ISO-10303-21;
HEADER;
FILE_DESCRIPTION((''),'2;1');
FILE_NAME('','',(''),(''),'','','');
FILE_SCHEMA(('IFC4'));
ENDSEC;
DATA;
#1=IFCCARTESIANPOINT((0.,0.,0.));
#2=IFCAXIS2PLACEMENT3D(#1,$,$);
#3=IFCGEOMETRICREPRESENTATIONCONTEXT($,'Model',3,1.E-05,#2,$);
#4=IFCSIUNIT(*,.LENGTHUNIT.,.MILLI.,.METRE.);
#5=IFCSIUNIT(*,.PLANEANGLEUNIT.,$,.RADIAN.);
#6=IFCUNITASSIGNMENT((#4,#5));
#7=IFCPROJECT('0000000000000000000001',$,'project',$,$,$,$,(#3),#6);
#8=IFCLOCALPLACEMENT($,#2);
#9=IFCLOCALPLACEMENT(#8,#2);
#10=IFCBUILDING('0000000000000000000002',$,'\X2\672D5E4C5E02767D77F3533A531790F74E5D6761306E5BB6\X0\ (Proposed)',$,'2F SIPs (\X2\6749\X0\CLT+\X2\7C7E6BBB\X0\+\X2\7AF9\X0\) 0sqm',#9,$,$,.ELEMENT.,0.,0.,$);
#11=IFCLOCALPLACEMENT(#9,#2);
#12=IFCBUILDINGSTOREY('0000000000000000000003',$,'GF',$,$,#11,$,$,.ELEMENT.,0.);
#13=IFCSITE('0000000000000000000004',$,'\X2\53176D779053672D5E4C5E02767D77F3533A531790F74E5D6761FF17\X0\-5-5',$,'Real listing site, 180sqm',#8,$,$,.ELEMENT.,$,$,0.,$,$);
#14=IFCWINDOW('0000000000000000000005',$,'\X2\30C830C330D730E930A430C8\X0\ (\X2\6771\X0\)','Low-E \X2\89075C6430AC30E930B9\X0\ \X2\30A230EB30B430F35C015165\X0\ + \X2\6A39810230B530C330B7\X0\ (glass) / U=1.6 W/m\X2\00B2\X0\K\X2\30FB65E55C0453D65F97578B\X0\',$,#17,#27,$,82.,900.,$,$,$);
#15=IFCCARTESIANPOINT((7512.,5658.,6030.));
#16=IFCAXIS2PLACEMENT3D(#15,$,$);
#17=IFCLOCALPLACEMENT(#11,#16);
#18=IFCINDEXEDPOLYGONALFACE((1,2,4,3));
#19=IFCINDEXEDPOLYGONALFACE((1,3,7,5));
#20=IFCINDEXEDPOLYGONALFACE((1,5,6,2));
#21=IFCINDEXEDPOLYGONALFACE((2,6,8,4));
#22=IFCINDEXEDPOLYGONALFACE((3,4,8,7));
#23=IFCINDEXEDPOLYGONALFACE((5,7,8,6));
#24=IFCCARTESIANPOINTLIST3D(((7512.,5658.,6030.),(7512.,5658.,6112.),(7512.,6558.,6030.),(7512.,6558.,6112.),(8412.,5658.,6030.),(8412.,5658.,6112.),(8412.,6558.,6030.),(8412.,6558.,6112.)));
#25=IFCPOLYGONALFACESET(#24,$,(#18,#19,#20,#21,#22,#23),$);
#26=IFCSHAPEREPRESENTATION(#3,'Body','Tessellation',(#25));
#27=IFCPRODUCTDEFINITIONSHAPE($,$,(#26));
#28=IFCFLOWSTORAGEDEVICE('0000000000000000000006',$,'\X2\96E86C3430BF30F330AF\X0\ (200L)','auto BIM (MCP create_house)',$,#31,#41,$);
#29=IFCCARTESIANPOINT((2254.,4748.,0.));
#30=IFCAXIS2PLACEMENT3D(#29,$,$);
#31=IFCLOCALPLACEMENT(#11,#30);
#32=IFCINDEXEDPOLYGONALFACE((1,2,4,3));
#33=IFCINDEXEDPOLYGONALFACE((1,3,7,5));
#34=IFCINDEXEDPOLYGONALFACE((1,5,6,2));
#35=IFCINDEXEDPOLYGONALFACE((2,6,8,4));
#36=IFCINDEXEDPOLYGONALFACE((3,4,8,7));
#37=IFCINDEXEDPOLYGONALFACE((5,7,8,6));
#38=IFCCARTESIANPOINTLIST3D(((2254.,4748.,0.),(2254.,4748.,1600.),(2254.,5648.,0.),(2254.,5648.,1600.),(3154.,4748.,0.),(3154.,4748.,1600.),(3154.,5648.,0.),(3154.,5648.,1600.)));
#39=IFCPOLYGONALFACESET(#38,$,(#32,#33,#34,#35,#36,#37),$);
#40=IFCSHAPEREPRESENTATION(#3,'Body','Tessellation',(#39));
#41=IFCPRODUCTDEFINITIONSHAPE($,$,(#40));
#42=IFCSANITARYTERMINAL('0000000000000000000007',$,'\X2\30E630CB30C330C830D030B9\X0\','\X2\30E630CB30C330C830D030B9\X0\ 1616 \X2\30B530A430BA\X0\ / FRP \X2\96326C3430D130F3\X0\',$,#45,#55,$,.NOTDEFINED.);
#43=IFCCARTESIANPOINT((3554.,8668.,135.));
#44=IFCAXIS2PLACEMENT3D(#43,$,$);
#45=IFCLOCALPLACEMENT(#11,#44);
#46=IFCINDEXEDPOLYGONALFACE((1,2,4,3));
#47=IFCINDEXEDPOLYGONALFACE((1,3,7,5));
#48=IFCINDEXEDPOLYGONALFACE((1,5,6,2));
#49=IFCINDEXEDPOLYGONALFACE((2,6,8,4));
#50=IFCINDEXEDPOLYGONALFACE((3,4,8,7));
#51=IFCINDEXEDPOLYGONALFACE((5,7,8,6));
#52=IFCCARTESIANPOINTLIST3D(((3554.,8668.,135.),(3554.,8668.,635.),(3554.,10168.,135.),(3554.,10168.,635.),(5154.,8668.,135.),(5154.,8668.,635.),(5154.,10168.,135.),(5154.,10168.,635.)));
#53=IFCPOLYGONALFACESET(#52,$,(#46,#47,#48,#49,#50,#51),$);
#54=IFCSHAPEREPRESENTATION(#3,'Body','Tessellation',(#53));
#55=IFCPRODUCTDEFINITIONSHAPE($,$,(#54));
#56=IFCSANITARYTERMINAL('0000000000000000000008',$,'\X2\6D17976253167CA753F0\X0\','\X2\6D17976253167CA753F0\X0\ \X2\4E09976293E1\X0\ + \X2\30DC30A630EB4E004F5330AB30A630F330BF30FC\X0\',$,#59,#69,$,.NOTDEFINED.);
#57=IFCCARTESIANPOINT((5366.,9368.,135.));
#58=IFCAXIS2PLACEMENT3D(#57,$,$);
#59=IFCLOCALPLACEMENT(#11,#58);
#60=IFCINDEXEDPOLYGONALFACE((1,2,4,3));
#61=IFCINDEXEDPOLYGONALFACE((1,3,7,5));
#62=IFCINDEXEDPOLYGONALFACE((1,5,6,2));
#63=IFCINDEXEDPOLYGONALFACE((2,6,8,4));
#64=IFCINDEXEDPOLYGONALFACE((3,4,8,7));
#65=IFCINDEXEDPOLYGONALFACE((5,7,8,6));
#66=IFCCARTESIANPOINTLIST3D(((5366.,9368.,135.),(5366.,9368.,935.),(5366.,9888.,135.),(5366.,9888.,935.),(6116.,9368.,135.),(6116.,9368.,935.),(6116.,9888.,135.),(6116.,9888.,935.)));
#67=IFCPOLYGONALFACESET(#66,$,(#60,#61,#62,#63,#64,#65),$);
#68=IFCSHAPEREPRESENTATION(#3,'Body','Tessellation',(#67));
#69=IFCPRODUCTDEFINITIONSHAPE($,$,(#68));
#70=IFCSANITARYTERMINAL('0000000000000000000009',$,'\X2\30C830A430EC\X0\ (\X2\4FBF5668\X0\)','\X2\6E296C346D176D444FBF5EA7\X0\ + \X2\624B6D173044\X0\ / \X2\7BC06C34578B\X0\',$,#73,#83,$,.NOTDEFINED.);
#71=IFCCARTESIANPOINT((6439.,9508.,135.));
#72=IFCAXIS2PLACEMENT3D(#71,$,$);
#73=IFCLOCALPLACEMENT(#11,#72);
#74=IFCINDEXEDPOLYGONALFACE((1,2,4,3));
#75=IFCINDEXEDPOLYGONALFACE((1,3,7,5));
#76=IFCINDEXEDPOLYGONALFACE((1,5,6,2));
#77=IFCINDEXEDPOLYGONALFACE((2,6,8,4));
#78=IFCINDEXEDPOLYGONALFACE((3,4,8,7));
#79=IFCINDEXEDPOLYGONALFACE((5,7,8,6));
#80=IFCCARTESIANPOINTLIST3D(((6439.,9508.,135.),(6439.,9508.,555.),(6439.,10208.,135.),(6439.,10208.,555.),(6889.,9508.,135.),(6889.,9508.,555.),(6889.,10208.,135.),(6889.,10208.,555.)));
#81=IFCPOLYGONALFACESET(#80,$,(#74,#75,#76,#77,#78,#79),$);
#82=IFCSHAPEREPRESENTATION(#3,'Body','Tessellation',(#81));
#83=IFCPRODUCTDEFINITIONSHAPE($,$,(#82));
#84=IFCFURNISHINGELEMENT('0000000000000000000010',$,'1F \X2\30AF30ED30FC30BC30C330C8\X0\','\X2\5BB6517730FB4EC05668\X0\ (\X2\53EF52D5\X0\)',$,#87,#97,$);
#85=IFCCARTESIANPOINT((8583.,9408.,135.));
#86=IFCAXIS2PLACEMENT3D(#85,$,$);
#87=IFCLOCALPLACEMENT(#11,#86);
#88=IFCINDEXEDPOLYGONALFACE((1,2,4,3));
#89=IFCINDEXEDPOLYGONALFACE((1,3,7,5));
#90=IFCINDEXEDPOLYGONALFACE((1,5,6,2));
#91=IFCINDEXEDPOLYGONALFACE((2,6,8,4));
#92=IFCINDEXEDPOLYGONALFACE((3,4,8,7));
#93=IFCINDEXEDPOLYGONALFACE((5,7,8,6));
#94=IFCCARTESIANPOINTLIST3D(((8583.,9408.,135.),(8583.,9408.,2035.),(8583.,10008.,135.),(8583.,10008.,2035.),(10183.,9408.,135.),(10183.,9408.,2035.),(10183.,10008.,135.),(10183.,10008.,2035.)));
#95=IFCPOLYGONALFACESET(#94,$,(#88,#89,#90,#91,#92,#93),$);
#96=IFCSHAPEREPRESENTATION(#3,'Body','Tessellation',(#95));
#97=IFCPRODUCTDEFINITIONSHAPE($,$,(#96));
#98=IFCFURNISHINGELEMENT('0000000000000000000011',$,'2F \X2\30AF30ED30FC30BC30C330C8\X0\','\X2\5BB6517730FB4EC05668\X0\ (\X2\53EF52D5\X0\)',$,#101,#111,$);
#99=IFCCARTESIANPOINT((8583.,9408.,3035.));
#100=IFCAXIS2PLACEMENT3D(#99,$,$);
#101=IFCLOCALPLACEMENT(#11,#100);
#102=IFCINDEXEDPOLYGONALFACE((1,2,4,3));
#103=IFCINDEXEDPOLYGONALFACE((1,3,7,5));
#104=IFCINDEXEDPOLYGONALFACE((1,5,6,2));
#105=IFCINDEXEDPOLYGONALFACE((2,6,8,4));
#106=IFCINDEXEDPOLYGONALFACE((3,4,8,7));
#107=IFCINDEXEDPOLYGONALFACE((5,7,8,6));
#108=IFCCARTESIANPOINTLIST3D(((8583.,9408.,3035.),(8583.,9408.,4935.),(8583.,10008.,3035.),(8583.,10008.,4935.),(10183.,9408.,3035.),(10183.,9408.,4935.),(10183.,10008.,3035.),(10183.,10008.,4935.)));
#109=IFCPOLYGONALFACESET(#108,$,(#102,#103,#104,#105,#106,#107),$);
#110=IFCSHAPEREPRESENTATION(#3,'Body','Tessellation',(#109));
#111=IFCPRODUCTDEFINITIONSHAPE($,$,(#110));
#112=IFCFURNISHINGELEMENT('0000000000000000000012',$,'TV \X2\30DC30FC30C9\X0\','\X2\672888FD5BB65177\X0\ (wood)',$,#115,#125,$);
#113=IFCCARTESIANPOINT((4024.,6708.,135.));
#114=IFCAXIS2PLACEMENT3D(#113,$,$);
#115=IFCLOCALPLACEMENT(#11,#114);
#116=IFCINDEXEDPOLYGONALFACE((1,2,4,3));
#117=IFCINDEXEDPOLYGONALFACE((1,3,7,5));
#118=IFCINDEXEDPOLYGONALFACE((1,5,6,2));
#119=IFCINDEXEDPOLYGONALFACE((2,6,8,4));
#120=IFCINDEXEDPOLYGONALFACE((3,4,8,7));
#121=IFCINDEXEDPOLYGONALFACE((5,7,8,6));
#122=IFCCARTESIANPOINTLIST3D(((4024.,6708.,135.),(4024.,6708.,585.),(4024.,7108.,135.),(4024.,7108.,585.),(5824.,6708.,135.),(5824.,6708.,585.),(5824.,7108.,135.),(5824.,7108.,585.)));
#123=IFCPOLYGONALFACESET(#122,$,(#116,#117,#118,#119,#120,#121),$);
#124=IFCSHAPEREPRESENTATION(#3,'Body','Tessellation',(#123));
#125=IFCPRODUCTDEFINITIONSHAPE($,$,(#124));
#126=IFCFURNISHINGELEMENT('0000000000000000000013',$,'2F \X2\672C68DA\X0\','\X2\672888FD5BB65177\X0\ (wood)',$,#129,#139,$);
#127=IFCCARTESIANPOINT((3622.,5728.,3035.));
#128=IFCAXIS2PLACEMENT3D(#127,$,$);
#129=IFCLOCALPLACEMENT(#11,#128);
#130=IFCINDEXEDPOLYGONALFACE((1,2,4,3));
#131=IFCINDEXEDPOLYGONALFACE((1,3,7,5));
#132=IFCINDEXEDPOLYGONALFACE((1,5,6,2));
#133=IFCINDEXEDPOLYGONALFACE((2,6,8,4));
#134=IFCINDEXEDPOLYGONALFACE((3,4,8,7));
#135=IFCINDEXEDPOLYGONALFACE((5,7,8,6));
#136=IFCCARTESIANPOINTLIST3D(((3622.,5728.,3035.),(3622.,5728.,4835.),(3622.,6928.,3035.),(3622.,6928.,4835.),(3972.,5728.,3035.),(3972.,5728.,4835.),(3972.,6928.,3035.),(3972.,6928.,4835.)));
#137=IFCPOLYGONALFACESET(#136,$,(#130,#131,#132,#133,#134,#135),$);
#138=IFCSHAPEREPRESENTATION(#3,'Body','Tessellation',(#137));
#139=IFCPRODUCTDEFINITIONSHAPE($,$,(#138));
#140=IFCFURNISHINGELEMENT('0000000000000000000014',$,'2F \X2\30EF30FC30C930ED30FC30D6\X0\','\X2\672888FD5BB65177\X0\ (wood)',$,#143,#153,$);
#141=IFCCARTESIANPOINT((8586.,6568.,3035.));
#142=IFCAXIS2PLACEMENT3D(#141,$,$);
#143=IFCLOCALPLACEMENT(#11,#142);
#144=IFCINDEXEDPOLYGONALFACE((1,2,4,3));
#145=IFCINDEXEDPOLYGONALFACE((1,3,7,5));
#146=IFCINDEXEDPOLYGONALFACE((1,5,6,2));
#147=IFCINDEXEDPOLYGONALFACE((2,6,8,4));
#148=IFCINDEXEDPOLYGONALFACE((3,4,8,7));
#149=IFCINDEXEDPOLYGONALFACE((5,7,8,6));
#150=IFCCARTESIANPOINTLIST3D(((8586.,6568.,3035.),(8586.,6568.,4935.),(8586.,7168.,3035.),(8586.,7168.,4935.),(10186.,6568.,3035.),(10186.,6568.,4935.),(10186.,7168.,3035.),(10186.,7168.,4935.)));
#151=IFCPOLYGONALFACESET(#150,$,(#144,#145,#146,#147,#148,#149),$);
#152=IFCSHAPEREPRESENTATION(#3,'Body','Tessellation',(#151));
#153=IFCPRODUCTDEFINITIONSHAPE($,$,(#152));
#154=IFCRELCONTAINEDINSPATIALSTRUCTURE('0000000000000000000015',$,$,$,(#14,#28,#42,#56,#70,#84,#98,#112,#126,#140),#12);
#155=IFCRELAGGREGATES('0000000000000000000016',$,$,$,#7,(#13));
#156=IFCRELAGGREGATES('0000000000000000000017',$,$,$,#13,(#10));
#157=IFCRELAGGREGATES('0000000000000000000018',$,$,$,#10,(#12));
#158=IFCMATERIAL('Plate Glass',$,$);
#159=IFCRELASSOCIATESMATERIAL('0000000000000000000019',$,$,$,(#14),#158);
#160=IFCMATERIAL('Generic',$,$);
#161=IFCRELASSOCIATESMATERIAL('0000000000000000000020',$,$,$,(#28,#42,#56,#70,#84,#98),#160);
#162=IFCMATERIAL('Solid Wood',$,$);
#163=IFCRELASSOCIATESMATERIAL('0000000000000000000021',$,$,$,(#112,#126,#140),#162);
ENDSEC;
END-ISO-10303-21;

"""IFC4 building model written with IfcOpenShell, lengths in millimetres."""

from ifc_helpers import new_model, si_unit, frame, frame_2d, origin, place, context, project, spatial, rectangle, extrude, material, element, save


model = new_model("IFC4")

# Units and contexts
model_context = context("Model", 3, precision=1e-05, world=origin())
ifc_project = project(units=[si_unit("LENGTHUNIT", "METRE", prefix="MILLI"), si_unit("PLANEANGLEUNIT", "RADIAN")], contexts=[model_context])

# Site, building, storey
site_placement = place(None, origin())
site = spatial("IfcSite", under=ifc_project, at=site_placement, Name="北海道札幌市白石区北郷九条７-5-5", ObjectType="Real listing site, 180sqm", CompositionType="ELEMENT", RefElevation=0.0)
building_placement = place(site_placement, origin())
building = spatial("IfcBuilding", under=site, at=building_placement, Name="札幌市白石区北郷九条の家 (Proposed)", ObjectType="2F SIPs (杉CLT+籾殻+竹) 0sqm", CompositionType="ELEMENT", ElevationOfRefHeight=0.0, ElevationOfTerrain=0.0)
storey_placement = place(building_placement, origin())
storey = spatial("IfcBuildingStorey", under=building, at=storey_placement, Name="GF", CompositionType="ELEMENT", Elevation=0.0)

# Shared definitions
ifc_material_1 = material(Name="Solid Wood")
ifc_material_2 = material(Name="Plate Glass")

# Window
window_1_placement = place(storey_placement, frame((7512.0, 5658.0, 6030.0)))
element("IfcWindow", 1, at=window_1_placement, inside=storey, material=ifc_material_2, Name="トップライト (東)", Description="Low-E 複層ガラス アルゴン封入 + 樹脂サッシ (glass) / U=1.6 W/m²K・日射取得型", OverallHeight=82.0, OverallWidth=900.0, context=model_context, shape_type="SweptSolid", body=[
    extrude(rectangle(XDim=900.0, YDim=900.0, at=frame_2d((450.0, 450.0))), frame((7512.0, 5658.0, 6030.0)), (0.0, 0.0, 1.0), 82.0),
])

# Flow storage device
ifc_material_3 = material(Name="Generic")
flow_storage_device_placement = place(storey_placement, frame((2254.0, 4748.0, 0.0)))
element("IfcFlowStorageDevice", 2, at=flow_storage_device_placement, inside=storey, material=ifc_material_3, Name="雨水タンク (200L)", Description="auto BIM (MCP create_house)", context=model_context, shape_type="SweptSolid", body=[
    extrude(rectangle(XDim=900.0, YDim=900.0, at=frame_2d((450.0, 450.0))), frame((2254.0, 4748.0, 0.0)), (0.0, 0.0, 1.0), 1600.0),
])

# Sanitary terminals
sanitary_terminal_1_placement = place(storey_placement, frame((3554.0, 8668.0, 135.0)))
element("IfcSanitaryTerminal", 3, at=sanitary_terminal_1_placement, inside=storey, material=ifc_material_3, Name="ユニットバス", Description="ユニットバス 1616 サイズ / FRP 防水パン", PredefinedType="NOTDEFINED", context=model_context, shape_type="SweptSolid", body=[
    extrude(rectangle(XDim=1600.0, YDim=1500.0, at=frame_2d((800.0, 750.0))), frame((3554.0, 8668.0, 135.0)), (0.0, 0.0, 1.0), 500.0),
])
sanitary_terminal_2_placement = place(storey_placement, frame((5366.0, 9368.0, 135.0)))
element("IfcSanitaryTerminal", 4, at=sanitary_terminal_2_placement, inside=storey, material=ifc_material_3, Name="洗面化粧台", Description="洗面化粧台 三面鏡 + ボウル一体カウンター", PredefinedType="NOTDEFINED", context=model_context, shape_type="SweptSolid", body=[
    extrude(rectangle(XDim=750.0, YDim=520.0, at=frame_2d((375.0, 260.0))), frame((5366.0, 9368.0, 135.0)), (0.0, 0.0, 1.0), 800.0),
])
sanitary_terminal_3_placement = place(storey_placement, frame((6439.0, 9508.0, 135.0)))
element("IfcSanitaryTerminal", 5, at=sanitary_terminal_3_placement, inside=storey, material=ifc_material_3, Name="トイレ (便器)", Description="温水洗浄便座 + 手洗い / 節水型", PredefinedType="NOTDEFINED", context=model_context, shape_type="SweptSolid", body=[
    extrude(rectangle(XDim=450.0, YDim=700.0, at=frame_2d((225.0, 350.0))), frame((6439.0, 9508.0, 135.0)), (0.0, 0.0, 1.0), 420.0),
])

# Furnishing elements
furnishing_1_placement = place(storey_placement, frame((8583.0, 9408.0, 135.0)))
element("IfcFurnishingElement", 6, at=furnishing_1_placement, inside=storey, material=ifc_material_3, Name="1F クローゼット", Description="家具・什器 (可動)", context=model_context, shape_type="SweptSolid", body=[
    extrude(rectangle(XDim=1600.0, YDim=600.0, at=frame_2d((800.0, 300.0))), frame((8583.0, 9408.0, 135.0)), (0.0, 0.0, 1.0), 1900.0),
])
furnishing_2_placement = place(storey_placement, frame((8583.0, 9408.0, 3035.0)))
element("IfcFurnishingElement", 7, at=furnishing_2_placement, inside=storey, material=ifc_material_3, Name="2F クローゼット", Description="家具・什器 (可動)", context=model_context, shape_type="SweptSolid", body=[
    extrude(rectangle(XDim=1600.0, YDim=600.0, at=frame_2d((800.0, 300.0))), frame((8583.0, 9408.0, 3035.0)), (0.0, 0.0, 1.0), 1900.0),
])
furnishing_3_placement = place(storey_placement, frame((4024.0, 6708.0, 135.0)))
element("IfcFurnishingElement", 8, at=furnishing_3_placement, inside=storey, material=ifc_material_1, Name="TV ボード", Description="木製家具 (wood)", context=model_context, shape_type="SweptSolid", body=[
    extrude(rectangle(XDim=1800.0, YDim=400.0, at=frame_2d((900.0, 200.0))), frame((4024.0, 6708.0, 135.0)), (0.0, 0.0, 1.0), 450.0),
])
furnishing_4_placement = place(storey_placement, frame((3622.0, 5728.0, 3035.0)))
element("IfcFurnishingElement", 9, at=furnishing_4_placement, inside=storey, material=ifc_material_1, Name="2F 本棚", Description="木製家具 (wood)", context=model_context, shape_type="SweptSolid", body=[
    extrude(rectangle(XDim=350.0, YDim=1200.0, at=frame_2d((175.0, 600.0))), frame((3622.0, 5728.0, 3035.0)), (0.0, 0.0, 1.0), 1800.0),
])
furnishing_5_placement = place(storey_placement, frame((8586.0, 6568.0, 3035.0)))
element("IfcFurnishingElement", 10, at=furnishing_5_placement, inside=storey, material=ifc_material_1, Name="2F ワードローブ", Description="木製家具 (wood)", context=model_context, shape_type="SweptSolid", body=[
    extrude(rectangle(XDim=1600.0, YDim=600.0, at=frame_2d((800.0, 300.0))), frame((8586.0, 6568.0, 3035.0)), (0.0, 0.0, 1.0), 1900.0),
])

save(model, "model.ifc")
